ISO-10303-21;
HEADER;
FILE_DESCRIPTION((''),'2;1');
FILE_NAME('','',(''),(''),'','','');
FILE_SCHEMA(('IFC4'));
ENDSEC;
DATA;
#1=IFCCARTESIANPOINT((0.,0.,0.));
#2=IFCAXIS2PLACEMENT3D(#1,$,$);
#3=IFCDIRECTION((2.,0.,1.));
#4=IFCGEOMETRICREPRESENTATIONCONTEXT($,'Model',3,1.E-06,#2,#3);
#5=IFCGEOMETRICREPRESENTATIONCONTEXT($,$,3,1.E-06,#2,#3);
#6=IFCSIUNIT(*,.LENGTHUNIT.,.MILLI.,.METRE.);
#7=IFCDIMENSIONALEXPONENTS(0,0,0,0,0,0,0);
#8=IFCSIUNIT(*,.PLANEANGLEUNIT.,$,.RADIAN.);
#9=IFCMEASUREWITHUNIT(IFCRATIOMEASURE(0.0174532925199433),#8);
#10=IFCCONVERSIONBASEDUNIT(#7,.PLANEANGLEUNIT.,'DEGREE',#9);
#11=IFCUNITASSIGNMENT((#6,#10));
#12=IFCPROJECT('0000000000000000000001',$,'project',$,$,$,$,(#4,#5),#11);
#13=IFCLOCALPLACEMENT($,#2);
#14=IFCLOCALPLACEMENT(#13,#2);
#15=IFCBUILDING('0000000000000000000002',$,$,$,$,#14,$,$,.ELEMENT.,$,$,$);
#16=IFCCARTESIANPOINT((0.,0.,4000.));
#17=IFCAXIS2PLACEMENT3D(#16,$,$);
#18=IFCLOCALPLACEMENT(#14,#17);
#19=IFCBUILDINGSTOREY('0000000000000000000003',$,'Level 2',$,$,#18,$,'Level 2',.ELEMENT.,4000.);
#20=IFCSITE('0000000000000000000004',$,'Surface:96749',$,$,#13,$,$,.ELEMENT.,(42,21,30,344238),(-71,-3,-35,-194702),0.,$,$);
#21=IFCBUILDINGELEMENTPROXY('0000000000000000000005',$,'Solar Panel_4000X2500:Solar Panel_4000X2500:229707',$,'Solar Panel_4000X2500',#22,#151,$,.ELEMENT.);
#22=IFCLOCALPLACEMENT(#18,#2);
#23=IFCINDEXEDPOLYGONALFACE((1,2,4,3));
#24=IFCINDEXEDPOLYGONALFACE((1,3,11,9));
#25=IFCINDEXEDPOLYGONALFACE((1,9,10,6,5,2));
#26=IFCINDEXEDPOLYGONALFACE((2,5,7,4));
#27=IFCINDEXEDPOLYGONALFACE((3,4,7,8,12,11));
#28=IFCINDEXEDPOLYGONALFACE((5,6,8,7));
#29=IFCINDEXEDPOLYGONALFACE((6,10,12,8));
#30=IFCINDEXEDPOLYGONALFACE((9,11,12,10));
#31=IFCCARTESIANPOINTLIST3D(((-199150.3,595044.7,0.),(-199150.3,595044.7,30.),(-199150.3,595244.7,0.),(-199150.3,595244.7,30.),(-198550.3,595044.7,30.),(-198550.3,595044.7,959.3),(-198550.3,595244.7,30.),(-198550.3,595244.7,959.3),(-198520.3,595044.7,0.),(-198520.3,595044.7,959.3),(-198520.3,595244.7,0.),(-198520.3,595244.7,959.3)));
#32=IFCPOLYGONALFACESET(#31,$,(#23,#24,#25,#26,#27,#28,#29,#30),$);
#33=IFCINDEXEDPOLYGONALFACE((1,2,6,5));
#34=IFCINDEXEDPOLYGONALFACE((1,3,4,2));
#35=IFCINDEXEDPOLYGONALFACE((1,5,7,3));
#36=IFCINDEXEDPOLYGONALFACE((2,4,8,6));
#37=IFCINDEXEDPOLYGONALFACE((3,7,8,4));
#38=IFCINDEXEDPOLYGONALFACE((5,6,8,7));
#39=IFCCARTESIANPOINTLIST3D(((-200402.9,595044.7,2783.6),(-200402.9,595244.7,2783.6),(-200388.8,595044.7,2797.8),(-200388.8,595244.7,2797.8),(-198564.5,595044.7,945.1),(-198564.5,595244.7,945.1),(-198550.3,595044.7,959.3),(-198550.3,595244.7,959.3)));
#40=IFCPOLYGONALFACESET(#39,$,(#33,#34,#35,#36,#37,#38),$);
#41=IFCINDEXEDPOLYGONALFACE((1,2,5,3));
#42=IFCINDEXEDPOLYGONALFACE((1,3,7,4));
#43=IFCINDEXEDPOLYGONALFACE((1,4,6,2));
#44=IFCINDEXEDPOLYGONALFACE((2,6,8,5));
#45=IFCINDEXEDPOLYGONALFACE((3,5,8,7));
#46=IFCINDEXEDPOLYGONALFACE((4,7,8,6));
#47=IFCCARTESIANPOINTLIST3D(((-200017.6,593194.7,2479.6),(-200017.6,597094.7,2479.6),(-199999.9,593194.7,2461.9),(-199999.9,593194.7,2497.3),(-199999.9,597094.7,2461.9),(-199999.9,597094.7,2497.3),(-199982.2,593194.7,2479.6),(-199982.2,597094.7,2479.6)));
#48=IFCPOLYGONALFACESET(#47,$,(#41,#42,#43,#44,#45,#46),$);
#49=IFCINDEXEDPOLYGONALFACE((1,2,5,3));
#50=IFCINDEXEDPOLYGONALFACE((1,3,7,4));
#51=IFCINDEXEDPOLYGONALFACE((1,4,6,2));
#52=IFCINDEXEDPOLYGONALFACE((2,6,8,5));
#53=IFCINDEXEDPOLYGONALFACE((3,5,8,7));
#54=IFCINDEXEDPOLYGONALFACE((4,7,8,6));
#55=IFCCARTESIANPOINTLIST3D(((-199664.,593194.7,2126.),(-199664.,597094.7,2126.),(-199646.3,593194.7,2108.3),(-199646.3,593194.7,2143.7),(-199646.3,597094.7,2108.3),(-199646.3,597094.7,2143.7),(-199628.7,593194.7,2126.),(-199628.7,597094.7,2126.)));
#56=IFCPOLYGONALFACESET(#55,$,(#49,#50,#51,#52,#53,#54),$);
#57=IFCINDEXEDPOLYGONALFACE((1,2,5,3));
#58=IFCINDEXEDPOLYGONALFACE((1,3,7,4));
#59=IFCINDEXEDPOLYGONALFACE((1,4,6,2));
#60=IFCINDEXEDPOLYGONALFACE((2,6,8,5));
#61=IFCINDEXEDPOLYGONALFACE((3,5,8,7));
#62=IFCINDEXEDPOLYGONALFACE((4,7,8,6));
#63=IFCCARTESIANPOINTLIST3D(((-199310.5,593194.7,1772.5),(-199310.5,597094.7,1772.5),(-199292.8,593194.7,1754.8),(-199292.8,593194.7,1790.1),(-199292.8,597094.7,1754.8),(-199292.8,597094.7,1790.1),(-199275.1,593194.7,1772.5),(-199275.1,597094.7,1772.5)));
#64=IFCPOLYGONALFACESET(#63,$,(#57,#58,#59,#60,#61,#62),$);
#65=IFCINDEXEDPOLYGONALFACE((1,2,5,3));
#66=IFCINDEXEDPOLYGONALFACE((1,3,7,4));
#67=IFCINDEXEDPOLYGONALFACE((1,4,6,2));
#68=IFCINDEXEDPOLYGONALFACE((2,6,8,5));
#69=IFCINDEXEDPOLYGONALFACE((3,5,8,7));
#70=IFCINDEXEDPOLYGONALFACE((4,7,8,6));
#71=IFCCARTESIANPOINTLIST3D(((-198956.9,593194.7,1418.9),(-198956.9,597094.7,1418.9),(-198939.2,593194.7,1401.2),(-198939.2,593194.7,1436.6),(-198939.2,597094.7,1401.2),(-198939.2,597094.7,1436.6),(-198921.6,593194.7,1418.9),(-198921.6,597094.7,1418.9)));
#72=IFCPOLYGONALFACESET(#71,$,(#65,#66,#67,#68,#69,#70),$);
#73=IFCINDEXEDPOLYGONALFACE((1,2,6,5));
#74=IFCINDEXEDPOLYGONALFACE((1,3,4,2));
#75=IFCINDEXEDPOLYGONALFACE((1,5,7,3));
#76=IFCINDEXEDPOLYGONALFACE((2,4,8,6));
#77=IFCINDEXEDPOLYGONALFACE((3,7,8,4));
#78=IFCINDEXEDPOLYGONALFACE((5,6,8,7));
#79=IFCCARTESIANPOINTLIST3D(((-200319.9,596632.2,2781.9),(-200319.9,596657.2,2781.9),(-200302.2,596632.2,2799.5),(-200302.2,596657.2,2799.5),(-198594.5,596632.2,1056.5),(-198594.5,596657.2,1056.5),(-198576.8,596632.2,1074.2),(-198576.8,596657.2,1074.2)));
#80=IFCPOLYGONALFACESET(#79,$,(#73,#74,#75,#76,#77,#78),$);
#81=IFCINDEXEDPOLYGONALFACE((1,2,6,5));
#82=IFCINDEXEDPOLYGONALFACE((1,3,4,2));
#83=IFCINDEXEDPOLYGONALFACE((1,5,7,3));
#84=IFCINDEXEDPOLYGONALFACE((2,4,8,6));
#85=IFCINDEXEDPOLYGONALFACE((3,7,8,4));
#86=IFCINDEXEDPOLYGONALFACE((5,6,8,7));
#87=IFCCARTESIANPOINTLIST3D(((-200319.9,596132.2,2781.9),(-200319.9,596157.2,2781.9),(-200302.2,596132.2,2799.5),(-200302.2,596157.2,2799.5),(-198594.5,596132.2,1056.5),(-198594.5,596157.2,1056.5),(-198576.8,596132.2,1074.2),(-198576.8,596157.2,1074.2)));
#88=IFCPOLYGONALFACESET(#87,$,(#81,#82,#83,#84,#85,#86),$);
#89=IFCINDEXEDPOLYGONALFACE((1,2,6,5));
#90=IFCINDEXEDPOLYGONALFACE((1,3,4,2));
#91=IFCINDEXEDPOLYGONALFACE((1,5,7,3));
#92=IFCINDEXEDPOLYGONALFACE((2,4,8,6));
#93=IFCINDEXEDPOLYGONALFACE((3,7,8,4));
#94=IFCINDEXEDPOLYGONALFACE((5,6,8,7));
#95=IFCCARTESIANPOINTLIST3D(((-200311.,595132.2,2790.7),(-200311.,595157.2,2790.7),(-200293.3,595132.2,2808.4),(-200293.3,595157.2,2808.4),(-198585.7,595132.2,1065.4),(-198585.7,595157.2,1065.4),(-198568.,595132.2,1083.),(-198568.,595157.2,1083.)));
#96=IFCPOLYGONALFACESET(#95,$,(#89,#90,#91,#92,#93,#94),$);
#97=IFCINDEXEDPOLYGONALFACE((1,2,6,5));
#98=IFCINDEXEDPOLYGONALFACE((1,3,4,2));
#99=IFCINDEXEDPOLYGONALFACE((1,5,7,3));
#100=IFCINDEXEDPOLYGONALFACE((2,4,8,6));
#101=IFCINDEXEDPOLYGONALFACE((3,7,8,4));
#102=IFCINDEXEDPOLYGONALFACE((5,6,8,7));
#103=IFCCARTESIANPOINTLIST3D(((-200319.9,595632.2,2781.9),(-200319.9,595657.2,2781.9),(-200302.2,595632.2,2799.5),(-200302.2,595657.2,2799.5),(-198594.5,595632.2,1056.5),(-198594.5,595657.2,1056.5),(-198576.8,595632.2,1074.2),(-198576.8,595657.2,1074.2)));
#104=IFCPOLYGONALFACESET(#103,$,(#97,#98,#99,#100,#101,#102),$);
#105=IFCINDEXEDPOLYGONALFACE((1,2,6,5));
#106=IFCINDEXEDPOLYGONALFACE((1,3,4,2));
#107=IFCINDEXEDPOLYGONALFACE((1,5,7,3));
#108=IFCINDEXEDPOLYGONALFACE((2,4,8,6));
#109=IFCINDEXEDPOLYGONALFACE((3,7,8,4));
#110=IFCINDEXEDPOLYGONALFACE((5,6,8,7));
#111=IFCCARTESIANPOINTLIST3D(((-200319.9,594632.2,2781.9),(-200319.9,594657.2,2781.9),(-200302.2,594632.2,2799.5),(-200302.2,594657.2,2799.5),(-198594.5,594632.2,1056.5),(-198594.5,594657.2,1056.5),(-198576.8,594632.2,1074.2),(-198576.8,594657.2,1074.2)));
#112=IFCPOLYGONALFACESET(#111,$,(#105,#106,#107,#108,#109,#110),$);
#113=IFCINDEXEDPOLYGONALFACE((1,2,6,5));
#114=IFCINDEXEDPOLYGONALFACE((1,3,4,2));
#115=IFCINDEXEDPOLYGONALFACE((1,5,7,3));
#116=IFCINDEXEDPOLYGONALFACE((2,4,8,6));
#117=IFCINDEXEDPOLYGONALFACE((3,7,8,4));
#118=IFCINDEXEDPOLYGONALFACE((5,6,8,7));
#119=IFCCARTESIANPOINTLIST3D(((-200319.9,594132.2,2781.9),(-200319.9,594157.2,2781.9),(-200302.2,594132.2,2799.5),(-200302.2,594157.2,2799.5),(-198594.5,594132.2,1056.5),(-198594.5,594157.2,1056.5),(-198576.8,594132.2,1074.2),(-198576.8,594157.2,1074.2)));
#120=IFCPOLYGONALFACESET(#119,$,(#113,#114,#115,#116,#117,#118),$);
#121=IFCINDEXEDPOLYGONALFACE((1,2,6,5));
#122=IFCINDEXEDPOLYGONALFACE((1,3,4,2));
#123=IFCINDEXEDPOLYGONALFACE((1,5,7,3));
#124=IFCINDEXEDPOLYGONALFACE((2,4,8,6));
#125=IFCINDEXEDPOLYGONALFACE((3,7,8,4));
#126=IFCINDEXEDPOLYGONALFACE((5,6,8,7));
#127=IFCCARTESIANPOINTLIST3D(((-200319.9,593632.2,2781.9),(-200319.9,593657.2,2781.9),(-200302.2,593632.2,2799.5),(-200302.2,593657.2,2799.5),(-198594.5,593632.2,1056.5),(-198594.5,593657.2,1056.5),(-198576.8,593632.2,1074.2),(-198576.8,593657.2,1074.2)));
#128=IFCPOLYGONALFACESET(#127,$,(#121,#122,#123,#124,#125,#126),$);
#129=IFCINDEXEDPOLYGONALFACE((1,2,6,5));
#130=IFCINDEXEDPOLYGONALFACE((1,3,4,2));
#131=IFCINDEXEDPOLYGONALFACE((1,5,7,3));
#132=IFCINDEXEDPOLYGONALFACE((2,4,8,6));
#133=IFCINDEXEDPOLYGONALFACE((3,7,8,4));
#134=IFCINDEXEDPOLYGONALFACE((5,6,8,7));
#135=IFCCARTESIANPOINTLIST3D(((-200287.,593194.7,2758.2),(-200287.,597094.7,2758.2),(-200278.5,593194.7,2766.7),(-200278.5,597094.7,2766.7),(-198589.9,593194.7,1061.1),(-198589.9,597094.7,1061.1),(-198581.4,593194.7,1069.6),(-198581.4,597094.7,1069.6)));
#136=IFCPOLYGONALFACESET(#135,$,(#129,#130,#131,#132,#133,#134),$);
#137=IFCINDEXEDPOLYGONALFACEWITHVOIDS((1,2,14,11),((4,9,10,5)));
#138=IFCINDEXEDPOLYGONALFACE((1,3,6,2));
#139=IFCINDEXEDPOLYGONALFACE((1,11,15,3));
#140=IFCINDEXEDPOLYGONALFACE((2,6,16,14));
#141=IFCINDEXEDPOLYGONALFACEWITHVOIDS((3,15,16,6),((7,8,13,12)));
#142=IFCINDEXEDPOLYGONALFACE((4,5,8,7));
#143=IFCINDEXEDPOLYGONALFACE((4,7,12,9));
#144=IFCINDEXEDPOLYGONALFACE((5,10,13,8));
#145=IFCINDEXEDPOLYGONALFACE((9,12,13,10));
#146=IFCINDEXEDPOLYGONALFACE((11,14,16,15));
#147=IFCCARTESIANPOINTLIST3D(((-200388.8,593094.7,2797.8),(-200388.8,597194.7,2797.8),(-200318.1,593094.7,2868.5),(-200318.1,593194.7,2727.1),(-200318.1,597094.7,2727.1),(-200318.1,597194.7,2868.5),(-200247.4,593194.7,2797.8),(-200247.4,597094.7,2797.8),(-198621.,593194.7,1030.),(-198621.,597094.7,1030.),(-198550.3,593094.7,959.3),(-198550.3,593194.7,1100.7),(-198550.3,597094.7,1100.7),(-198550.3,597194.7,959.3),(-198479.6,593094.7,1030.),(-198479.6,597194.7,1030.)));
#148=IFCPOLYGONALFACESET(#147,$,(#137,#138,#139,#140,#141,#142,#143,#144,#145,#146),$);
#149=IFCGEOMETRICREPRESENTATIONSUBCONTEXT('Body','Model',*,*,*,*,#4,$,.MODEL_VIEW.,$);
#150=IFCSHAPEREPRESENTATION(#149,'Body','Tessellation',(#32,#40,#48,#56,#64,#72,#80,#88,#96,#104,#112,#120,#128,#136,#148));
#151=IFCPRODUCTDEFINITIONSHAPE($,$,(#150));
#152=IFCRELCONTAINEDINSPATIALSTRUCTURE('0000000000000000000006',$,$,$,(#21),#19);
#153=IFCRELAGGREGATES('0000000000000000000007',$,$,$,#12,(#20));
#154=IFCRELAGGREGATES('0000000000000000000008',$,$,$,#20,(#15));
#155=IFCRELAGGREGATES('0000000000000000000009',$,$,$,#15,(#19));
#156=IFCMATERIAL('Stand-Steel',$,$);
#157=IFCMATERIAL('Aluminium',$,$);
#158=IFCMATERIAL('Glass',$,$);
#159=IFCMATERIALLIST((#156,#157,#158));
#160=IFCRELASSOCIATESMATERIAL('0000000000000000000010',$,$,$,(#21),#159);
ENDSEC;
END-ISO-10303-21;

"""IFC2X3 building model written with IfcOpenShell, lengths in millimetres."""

from ifc_helpers import new_model, entity, si_unit, converted_unit, direction, frame, frame_2d, origin, origin_2d_with_axis, place, context, subcontext, project, spatial, polyline, rectangle, outline, extrude, source, transform, mapped, material, material_list, element, save


model = new_model("IFC2X3")

# Units and contexts
model_context = context("Model", 3, precision=1e-06, world=origin(), true_north=direction((2.0, 0.0, 1.0)))
context_of_model = context(None, 3, precision=1e-06, world=origin(), true_north=direction((2.0, 0.0, 1.0)))
body_context = subcontext(model_context, "Body", "Model", "MODEL_VIEW")
ifc_project = project(units=[si_unit("LENGTHUNIT", "METRE", prefix="MILLI"), converted_unit("PLANEANGLEUNIT", "DEGREE", entity("IfcRatioMeasure", 0.0174532925199433), si_unit("PLANEANGLEUNIT", "RADIAN"), dimensions=[0, 0, 0, 0, 0, 0, 0])], contexts=[model_context, context_of_model])

# Site, building, storey
site_placement = place(None, origin())
site = spatial("IfcSite", under=ifc_project, at=site_placement, Name="Surface:96749", CompositionType="ELEMENT", RefLatitude=(42, 21, 30, 344238), RefLongitude=(-71, -3, -35, -194702), RefElevation=0.0)
building_placement = place(site_placement, origin())
building = spatial("IfcBuilding", under=site, at=building_placement, CompositionType="ELEMENT")
storey_placement = place(building_placement, frame((0.0, 0.0, 4000.0)))
storey = spatial("IfcBuildingStorey", under=building, at=storey_placement, Name="Level 2", LongName="Level 2", CompositionType="ELEMENT", Elevation=4000.0)

# Building element proxy
ifc_material_1 = material(Name="Stand-Steel")
ifc_material_2 = material(Name="Aluminium")
ifc_material_3 = material(Name="Glass")
shared_shape = source(origin(), body_context, "Body", "SweptSolid", [
    extrude(outline(polyline([(-629.5, -220.0), (329.8, -220.0), (329.8, 410.0), (299.8, 410.0), (299.8, -190.0), (-629.5, -190.0), (-629.5, -220.0)])), frame((-190.0, -100.0, 299.8), z_axis=(0.0, 1.0, 0.0), x_axis=(0.0, 0.0, -1.0)), (0.0, 0.0, 1.0), 200.0),
    extrude(rectangle(XDim=20.0, YDim=200.0, at=frame_2d((0.0, 0.0), x_axis=(0.0, 1.0))), frame((-7.1, 0.0, 922.2), z_axis=(-0.707107, 0.0, 0.707107), x_axis=(0.0, 1.0, 0.0)), (0.0, 0.0, 1.0), 2600.0),
    extrude(rectangle(XDim=25.0, YDim=25.0, at=frame_2d((0.0, 0.0), x_axis=(1.0, 0.0))), frame((-1449.6, -1950.0, 2449.6), z_axis=(0.0, 1.0, 0.0), x_axis=(-0.707107, 0.0, -0.707107)), (0.0, 0.0, 1.0), 3900.0),
    extrude(rectangle(XDim=25.0, YDim=25.0, at=origin_2d_with_axis()), frame((-1096.0, -1950.0, 2096.0), z_axis=(0.0, 1.0, 0.0), x_axis=(-0.707107, 0.0, -0.707107)), (0.0, 0.0, 1.0), 3900.0),
    extrude(rectangle(XDim=25.0, YDim=25.0, at=origin_2d_with_axis()), frame((-742.5, -1950.0, 1742.5), z_axis=(0.0, 1.0, 0.0), x_axis=(-0.707107, 0.0, -0.707107)), (0.0, 0.0, 1.0), 3900.0),
    extrude(rectangle(XDim=25.0, YDim=25.0, at=frame_2d((0.0, 0.0), x_axis=(1.0, 0.0))), frame((-388.9, -1950.0, 1388.9), z_axis=(0.0, 1.0, 0.0), x_axis=(-0.707107, 0.0, -0.707107)), (0.0, 0.0, 1.0), 3900.0),
    extrude(rectangle(XDim=25.0, YDim=25.0, at=frame_2d((0.0, 0.0), x_axis=(0.0, 1.0))), frame((-35.4, 1500.0, 1035.4), z_axis=(-0.707107, 0.0, 0.707107), x_axis=(0.0, 1.0, 0.0)), (0.0, 0.0, 1.0), 2440.0),
    extrude(rectangle(XDim=25.0, YDim=25.0, at=frame_2d((0.0, 0.0), x_axis=(0.0, 1.0))), frame((-35.4, 1000.0, 1035.4), z_axis=(-0.707107, 0.0, 0.707107), x_axis=(0.0, 1.0, 0.0)), (0.0, 0.0, 1.0), 2440.0),
    extrude(rectangle(XDim=25.0, YDim=25.0, at=frame_2d((0.0, 0.0), x_axis=(0.0, 1.0))), frame((-26.5, 0.0, 1044.2), z_axis=(-0.707107, 0.0, 0.707107), x_axis=(0.0, -1.0, 0.0)), (0.0, 0.0, 1.0), 2440.0),
    extrude(rectangle(XDim=25.0, YDim=25.0, at=frame_2d((0.0, 0.0), x_axis=(0.0, 1.0))), frame((-35.4, 500.0, 1035.4), z_axis=(-0.707107, 0.0, 0.707107), x_axis=(0.0, 1.0, 0.0)), (0.0, 0.0, 1.0), 2440.0),
    extrude(rectangle(XDim=25.0, YDim=25.0, at=frame_2d((0.0, 0.0), x_axis=(0.0, 1.0))), frame((-35.4, -500.0, 1035.4), z_axis=(-0.707107, 0.0, 0.707107), x_axis=(0.0, 1.0, 0.0)), (0.0, 0.0, 1.0), 2440.0),
    extrude(rectangle(XDim=25.0, YDim=25.0, at=frame_2d((0.0, 0.0), x_axis=(0.0, 1.0))), frame((-35.4, -1000.0, 1035.4), z_axis=(-0.707107, 0.0, 0.707107), x_axis=(0.0, 1.0, 0.0)), (0.0, 0.0, 1.0), 2440.0),
    extrude(rectangle(XDim=25.0, YDim=25.0, at=frame_2d((0.0, 0.0), x_axis=(0.0, 1.0))), frame((-35.4, -1500.0, 1035.4), z_axis=(-0.707107, 0.0, 0.707107), x_axis=(0.0, 1.0, 0.0)), (0.0, 0.0, 1.0), 2440.0),
    extrude(rectangle(XDim=2400.0, YDim=12.0, at=frame_2d((0.0, 0.0), x_axis=(1.0, 0.0))), frame((-883.9, -1950.0, 1883.9), z_axis=(0.0, 1.0, 0.0), x_axis=(0.707107, 0.0, -0.707107)), (0.0, 0.0, 1.0), 3900.0),
    extrude(outline(polyline([(-2050.0, -1300.0), (2050.0, -1300.0), (2050.0, 1300.0), (-2050.0, 1300.0), (-2050.0, -1300.0)]), holes=[polyline([(1950.0, -1200.0), (-1950.0, -1200.0), (-1950.0, 1200.0), (1950.0, 1200.0), (1950.0, -1200.0)])]), frame((-919.2, 0.0, 1848.5), z_axis=(0.707107, 0.0, 0.707107), x_axis=(0.0, 1.0, 0.0)), (0.0, 0.0, 1.0), 100.0),
])
ifc_material_list_1 = material_list([ifc_material_1, ifc_material_2, ifc_material_3])
proxy_1_placement = place(storey_placement, frame((-198550.3, 595144.7, 30.0)))
element("IfcBuildingElementProxy", 1, at=proxy_1_placement, inside=storey, material=ifc_material_list_1, Name="Solar Panel_4000X2500:Solar Panel_4000X2500:229707", ObjectType="Solar Panel_4000X2500", CompositionType="ELEMENT", context=body_context, shape_type="MappedRepresentation", body=[
    mapped(shared_shape, transform((0.0, 0.0, 0.0), scale=1.0)),
])

save(model, "model.ifc")
